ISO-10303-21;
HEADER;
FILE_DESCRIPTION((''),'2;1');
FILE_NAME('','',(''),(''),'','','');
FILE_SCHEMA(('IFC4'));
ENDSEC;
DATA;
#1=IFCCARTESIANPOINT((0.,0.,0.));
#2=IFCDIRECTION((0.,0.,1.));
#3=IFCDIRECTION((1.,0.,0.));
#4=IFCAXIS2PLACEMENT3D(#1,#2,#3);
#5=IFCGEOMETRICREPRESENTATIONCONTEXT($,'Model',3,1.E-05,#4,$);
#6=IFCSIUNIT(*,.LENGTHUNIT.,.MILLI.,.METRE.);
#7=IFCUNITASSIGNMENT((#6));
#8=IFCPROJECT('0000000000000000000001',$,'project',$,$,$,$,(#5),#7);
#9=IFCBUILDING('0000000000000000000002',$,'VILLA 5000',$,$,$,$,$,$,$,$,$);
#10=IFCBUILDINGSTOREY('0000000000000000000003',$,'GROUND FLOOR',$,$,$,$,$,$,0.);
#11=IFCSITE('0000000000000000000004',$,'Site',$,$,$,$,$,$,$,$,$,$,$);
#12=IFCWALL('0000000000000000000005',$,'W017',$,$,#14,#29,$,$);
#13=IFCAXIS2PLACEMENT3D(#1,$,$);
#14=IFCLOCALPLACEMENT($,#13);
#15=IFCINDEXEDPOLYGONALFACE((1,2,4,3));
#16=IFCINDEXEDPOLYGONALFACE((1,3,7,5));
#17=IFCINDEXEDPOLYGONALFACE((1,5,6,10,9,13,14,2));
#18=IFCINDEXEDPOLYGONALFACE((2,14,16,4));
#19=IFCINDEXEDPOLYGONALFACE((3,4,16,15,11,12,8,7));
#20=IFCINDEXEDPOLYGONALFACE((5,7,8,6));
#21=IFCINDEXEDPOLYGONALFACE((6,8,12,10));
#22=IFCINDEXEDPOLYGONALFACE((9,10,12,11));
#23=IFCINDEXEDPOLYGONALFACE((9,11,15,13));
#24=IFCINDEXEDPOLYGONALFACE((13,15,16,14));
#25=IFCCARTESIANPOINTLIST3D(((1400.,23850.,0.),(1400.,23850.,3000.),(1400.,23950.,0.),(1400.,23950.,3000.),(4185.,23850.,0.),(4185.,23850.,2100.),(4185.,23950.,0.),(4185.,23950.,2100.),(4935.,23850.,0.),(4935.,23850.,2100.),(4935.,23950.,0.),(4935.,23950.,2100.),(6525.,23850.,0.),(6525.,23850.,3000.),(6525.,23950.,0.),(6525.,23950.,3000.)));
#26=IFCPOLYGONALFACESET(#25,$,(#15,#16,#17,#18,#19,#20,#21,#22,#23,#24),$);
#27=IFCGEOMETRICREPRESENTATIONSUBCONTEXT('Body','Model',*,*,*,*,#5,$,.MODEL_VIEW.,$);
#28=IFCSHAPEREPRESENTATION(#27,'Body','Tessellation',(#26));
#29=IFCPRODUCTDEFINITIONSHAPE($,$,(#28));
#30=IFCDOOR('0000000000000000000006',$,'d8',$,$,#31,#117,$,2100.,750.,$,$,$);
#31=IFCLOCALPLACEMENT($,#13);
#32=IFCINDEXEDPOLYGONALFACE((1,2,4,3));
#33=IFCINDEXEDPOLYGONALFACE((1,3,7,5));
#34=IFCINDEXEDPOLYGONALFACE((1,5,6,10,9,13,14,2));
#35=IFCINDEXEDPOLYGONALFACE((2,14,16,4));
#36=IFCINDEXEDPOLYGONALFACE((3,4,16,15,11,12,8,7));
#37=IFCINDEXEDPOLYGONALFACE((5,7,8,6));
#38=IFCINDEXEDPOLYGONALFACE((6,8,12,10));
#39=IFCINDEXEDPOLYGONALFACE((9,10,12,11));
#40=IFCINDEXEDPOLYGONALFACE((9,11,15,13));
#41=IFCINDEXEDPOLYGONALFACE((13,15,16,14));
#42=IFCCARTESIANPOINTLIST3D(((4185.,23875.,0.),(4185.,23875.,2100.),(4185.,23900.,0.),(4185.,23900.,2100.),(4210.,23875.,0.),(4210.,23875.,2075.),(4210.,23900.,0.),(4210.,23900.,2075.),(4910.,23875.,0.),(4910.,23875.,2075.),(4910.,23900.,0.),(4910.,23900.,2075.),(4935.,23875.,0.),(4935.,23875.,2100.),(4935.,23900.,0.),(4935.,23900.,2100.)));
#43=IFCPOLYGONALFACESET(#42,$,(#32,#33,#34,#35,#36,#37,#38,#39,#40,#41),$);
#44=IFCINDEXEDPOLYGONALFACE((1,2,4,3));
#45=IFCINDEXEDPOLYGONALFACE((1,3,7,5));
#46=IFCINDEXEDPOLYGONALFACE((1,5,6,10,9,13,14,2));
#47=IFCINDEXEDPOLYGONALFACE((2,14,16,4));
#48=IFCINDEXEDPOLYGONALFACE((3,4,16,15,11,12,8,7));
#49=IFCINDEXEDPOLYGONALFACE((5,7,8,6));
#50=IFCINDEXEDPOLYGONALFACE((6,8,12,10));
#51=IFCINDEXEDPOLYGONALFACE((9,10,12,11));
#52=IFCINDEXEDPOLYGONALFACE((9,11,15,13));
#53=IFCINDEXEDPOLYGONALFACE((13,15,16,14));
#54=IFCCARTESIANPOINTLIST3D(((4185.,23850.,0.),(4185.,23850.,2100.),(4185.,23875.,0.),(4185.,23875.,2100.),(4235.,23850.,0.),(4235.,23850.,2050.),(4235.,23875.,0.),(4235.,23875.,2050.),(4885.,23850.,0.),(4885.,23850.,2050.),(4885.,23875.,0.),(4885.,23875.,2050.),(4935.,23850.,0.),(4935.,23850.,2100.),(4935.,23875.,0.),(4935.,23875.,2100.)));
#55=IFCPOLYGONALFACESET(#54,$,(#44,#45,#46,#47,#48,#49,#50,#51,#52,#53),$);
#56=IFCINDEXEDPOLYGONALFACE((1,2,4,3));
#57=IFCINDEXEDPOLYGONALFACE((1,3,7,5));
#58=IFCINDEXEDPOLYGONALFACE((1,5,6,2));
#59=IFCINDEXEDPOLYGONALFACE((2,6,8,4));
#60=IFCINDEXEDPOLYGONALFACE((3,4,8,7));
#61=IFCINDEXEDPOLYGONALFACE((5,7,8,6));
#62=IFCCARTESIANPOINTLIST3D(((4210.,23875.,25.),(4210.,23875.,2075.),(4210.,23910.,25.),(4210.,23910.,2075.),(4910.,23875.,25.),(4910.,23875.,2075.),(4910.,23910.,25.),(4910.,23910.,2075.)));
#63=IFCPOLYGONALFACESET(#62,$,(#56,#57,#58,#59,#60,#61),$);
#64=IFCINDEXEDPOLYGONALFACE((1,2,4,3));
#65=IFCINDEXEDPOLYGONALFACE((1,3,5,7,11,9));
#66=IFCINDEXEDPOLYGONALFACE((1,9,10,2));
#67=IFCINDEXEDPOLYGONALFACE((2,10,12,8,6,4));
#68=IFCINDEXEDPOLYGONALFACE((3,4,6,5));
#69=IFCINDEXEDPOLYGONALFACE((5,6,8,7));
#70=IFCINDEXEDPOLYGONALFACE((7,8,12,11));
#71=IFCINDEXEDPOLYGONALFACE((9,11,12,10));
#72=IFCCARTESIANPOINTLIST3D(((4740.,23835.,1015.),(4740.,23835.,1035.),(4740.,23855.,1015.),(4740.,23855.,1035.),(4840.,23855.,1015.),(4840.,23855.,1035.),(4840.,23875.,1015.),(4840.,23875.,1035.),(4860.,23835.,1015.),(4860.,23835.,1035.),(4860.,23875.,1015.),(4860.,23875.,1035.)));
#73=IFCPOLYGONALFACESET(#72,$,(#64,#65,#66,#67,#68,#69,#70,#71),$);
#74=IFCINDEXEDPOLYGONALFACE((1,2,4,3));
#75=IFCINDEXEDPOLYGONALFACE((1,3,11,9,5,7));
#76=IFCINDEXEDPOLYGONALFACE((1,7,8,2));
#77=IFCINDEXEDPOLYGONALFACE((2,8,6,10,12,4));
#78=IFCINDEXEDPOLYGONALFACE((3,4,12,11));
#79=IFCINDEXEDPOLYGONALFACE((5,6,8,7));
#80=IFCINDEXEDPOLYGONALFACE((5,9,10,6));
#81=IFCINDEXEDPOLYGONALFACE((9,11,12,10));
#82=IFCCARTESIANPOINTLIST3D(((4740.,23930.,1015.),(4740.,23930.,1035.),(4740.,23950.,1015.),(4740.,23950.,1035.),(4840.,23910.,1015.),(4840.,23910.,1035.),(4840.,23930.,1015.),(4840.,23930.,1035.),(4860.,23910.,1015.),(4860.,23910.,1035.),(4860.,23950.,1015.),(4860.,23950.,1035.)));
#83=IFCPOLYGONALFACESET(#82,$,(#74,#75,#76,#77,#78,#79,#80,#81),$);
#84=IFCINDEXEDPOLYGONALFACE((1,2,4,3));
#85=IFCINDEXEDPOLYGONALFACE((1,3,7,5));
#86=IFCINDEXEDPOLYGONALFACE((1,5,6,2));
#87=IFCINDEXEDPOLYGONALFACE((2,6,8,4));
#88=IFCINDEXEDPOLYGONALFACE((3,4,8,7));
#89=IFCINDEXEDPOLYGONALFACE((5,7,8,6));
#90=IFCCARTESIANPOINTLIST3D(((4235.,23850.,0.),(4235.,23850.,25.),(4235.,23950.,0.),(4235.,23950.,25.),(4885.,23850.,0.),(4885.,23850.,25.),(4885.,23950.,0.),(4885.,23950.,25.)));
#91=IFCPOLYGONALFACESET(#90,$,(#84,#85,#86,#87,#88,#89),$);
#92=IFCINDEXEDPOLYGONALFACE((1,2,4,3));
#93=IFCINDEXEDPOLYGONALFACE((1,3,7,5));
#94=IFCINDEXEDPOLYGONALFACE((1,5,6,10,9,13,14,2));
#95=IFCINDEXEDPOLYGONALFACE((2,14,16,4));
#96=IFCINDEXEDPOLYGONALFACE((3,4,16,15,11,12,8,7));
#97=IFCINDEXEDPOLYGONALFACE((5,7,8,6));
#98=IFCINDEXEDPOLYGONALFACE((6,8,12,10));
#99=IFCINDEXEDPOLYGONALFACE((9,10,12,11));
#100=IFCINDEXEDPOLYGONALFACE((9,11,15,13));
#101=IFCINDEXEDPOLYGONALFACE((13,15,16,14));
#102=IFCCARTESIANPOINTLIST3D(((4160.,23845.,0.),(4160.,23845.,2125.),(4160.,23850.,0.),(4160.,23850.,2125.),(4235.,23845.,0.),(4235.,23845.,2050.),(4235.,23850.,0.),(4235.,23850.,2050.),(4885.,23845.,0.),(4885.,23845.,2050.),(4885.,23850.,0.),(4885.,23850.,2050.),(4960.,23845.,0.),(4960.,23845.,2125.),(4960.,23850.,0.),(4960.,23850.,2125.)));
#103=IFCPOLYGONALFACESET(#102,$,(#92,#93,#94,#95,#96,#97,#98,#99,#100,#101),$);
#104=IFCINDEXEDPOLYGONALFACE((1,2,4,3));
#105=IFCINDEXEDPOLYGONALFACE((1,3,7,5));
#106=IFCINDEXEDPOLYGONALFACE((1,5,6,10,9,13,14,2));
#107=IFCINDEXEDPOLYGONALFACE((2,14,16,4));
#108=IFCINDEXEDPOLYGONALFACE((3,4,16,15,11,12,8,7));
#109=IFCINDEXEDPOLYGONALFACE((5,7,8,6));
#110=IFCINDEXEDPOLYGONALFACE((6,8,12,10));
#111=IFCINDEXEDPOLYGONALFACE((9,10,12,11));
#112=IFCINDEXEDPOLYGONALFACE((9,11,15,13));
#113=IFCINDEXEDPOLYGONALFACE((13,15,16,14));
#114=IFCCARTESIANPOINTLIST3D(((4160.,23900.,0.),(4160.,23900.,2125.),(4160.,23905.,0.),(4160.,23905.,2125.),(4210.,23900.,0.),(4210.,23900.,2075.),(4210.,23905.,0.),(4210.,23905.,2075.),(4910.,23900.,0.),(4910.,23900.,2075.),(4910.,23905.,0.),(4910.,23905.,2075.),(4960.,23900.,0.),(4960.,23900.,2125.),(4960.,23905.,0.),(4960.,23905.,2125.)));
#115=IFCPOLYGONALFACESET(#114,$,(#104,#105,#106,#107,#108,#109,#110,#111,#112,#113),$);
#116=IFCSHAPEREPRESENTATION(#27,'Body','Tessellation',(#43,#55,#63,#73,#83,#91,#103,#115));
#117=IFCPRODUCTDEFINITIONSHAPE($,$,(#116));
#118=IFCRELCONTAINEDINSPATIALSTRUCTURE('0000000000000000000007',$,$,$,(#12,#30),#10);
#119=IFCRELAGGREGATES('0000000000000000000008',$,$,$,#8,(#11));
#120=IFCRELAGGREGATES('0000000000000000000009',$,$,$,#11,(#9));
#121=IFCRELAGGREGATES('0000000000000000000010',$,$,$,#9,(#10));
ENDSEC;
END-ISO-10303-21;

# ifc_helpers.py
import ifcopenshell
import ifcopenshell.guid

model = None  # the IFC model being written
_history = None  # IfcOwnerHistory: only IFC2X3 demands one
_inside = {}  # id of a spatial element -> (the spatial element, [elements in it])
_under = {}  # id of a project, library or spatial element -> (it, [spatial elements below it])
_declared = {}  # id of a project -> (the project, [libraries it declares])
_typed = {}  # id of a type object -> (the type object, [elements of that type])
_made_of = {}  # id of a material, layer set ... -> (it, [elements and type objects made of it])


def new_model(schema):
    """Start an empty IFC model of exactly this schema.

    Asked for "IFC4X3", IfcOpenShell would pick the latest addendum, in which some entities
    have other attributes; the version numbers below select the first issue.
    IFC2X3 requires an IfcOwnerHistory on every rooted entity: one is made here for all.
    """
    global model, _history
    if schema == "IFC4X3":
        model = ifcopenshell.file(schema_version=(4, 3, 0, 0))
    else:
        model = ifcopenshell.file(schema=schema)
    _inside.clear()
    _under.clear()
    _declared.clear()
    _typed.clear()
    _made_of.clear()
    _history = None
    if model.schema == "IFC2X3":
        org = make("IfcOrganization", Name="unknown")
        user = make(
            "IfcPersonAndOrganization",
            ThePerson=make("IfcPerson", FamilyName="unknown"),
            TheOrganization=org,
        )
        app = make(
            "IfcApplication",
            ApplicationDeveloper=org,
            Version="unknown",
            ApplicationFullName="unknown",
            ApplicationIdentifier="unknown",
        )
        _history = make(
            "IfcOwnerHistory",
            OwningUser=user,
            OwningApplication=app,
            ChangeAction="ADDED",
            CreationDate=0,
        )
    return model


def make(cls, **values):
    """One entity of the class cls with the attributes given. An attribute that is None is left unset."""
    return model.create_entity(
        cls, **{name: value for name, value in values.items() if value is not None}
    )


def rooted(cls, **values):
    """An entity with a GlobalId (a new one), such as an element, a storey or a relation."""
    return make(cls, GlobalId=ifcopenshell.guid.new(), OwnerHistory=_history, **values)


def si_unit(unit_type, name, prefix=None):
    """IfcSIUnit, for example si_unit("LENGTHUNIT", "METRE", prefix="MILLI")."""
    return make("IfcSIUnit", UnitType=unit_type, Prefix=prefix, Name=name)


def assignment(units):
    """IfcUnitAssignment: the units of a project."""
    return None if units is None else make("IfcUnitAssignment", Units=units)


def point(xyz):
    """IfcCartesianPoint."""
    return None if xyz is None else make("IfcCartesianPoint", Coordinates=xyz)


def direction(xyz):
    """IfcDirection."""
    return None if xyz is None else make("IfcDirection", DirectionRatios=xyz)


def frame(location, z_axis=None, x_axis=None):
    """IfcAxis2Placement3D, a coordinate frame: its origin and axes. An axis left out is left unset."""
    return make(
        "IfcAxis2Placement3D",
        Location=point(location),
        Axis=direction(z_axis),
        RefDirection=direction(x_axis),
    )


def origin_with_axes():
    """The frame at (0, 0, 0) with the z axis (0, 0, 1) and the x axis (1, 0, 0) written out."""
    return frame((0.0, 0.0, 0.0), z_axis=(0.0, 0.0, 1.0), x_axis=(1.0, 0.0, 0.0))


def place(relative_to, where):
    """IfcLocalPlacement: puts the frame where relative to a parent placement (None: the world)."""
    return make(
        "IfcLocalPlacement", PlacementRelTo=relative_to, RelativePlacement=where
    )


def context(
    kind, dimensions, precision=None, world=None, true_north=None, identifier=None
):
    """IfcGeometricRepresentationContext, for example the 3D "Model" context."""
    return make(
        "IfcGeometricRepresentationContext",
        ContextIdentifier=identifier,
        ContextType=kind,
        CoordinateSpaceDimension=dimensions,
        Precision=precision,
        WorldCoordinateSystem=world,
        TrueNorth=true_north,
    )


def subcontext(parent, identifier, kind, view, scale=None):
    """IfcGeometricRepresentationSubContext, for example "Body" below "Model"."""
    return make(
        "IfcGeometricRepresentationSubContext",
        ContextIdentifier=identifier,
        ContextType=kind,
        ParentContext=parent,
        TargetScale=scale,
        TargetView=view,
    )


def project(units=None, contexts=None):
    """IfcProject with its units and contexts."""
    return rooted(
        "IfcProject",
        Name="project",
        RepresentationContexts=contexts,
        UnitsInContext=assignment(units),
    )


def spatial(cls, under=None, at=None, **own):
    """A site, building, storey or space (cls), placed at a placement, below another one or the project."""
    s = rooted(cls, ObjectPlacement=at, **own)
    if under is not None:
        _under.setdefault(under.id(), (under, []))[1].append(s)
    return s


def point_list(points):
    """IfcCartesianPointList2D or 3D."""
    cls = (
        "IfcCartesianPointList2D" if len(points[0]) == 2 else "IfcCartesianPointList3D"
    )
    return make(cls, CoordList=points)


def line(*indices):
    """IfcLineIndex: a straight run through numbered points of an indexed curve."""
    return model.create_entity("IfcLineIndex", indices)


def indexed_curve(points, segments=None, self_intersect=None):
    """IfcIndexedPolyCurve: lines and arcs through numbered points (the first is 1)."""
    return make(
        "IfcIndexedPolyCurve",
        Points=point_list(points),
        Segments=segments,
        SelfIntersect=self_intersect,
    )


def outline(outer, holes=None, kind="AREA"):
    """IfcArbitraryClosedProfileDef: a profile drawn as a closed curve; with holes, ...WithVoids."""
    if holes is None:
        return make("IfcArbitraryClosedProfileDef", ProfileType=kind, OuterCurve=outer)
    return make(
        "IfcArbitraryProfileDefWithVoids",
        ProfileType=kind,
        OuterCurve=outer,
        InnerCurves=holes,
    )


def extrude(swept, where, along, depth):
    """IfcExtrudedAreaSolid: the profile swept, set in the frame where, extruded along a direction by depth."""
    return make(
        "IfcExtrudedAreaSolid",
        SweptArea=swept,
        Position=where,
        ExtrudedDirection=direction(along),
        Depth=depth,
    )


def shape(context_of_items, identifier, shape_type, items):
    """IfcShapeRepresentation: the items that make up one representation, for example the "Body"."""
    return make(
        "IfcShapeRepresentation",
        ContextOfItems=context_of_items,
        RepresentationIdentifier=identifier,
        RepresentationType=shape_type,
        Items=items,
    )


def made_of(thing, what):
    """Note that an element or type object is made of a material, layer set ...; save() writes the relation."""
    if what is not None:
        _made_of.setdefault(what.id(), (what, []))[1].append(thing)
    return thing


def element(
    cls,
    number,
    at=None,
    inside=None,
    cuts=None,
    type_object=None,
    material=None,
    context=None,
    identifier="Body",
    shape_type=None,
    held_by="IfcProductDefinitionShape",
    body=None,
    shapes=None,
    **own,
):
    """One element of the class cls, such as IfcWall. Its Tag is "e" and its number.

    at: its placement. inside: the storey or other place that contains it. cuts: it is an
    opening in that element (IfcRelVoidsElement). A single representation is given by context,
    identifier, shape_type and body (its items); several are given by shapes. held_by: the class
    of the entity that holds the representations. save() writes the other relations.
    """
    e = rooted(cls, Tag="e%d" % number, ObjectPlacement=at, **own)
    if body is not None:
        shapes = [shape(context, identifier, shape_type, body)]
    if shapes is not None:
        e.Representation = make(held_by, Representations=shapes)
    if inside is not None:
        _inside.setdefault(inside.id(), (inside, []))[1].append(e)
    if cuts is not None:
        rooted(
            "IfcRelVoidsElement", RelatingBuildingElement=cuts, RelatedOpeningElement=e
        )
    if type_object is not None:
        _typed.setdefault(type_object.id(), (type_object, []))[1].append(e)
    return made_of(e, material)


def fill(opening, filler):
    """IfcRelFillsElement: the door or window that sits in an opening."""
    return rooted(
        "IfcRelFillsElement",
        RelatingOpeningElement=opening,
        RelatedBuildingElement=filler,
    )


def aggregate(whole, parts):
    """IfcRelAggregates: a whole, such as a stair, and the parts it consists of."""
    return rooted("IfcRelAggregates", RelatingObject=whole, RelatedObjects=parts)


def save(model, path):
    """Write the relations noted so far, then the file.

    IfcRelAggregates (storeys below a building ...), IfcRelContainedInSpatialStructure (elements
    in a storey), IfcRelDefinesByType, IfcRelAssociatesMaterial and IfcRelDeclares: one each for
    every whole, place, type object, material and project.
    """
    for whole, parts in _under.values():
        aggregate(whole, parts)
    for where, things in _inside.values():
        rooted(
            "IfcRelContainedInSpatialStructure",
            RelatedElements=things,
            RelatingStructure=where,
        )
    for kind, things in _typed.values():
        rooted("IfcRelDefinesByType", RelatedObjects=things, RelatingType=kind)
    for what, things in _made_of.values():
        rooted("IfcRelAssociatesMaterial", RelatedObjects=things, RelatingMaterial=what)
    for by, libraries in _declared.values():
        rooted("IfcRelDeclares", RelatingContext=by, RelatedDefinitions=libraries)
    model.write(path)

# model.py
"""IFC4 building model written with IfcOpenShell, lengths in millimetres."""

from ifc_helpers import new_model, si_unit, frame, origin_with_axes, place, context, subcontext, project, spatial, line, indexed_curve, outline, extrude, element, fill, save


model = new_model("IFC4")

# Units and contexts
model_context = context("Model", 3, precision=1e-05, world=origin_with_axes())
body_context = subcontext(model_context, "Body", "Model", "MODEL_VIEW")
ifc_project = project(units=[si_unit("LENGTHUNIT", "METRE", prefix="MILLI")], contexts=[model_context])

# Site, building, storey
site = spatial("IfcSite", under=ifc_project, Name="Site")
building = spatial("IfcBuilding", under=site, Name="VILLA 5000")
storey = spatial("IfcBuildingStorey", under=building, Name="GROUND FLOOR", Elevation=0.0)

# Wall, opening, door
wall_1_placement = place(None, frame((1400.0, 23900.0, 0.0), z_axis=(0.0, 0.0, 1.0), x_axis=(1.0, 0.0, 0.0)))
wall_1 = element("IfcWall", 1, at=wall_1_placement, inside=storey, Name="W017", context=body_context, shape_type="SweptSolid", body=[
    extrude(outline(indexed_curve([(0.0, 0.0), (0.0, 100.0), (5125.0, 100.0), (5125.0, 0.0), (0.0, 0.0)], self_intersect=False)), frame((0.0, -50.0, 0.0), z_axis=(0.0, 0.0, 1.0), x_axis=(1.0, 0.0, 0.0)), (0.0, 0.0, 1.0), 3000.0),
])
opening_1_placement = place(wall_1_placement, frame((2785.0, 0.0, 0.0), z_axis=(0.0, 0.0, 1.0), x_axis=(1.0, 0.0, 0.0)))
opening_1 = element("IfcOpeningElement", 2, at=opening_1_placement, cuts=wall_1, context=body_context, shape_type="SweptSolid", body=[
    extrude(outline(indexed_curve([(0.0, 0.0), (0.0, 200.0), (750.0, 200.0), (750.0, 0.0), (0.0, 0.0)], self_intersect=False)), frame((0.0, -100.0, 0.0), z_axis=(0.0, 0.0, 1.0), x_axis=(1.0, 0.0, 0.0)), (0.0, 0.0, 1.0), 2100.0),
])
door_1_placement = place(None, frame((4185.0, 23850.0, 0.0), z_axis=(0.0, 0.0, 1.0), x_axis=(1.0, 0.0, 0.0)))
door_1 = element("IfcDoor", 3, at=door_1_placement, inside=storey, Name="d8", OverallHeight=2100.0, OverallWidth=750.0, context=body_context, shape_type="SweptSolid", body=[
    extrude(outline(indexed_curve([(0.0, 0.0), (0.0, 2100.0), (750.0, 2100.0), (750.0, 0.0), (725.0, 0.0), (725.0, 2075.0), (25.0, 2075.0), (25.0, 0.0)], segments=[line(1, 2, 3, 4, 5, 6, 7, 8, 1)])), frame((0.0, 25.0, 0.0), z_axis=(0.0, -1.0, 0.0), x_axis=(1.0, 0.0, 0.0)), (0.0, 0.0, -1.0), 25.0),
    extrude(outline(indexed_curve([(0.0, 0.0), (0.0, 2100.0), (750.0, 2100.0), (750.0, 0.0), (700.0, 0.0), (700.0, 2050.0), (50.0, 2050.0), (50.0, 0.0)], segments=[line(1, 2, 3, 4, 5, 6, 7, 8, 1)])), frame((0.0, 0.0, 0.0), z_axis=(0.0, -1.0, 0.0), x_axis=(1.0, 0.0, 0.0)), (0.0, 0.0, -1.0), 25.0),
    extrude(outline(indexed_curve([(0.0, 0.0), (700.0, 0.0), (700.0, 35.0), (0.0, 35.0)], segments=[line(1, 2, 3, 4, 1)])), frame((25.0, 25.0, 25.0), z_axis=(0.0, 0.0, 1.0), x_axis=(1.0, 0.0, 0.0)), (0.0, 0.0, 1.0), 2050.0),
    extrude(outline(indexed_curve([(0.0, 0.0), (0.0, -40.0), (-120.0, -40.0), (-120.0, -20.0), (-20.0, -20.0), (-20.0, 0.0)], segments=[line(1, 2, 3, 4, 5, 6, 1)])), frame((675.0, 25.0, 1015.0), z_axis=(0.0, 0.0, 1.0), x_axis=(1.0, 0.0, 0.0)), (0.0, 0.0, 1.0), 20.0),
    extrude(outline(indexed_curve([(0.0, 0.0), (0.0, 40.0), (-120.0, 40.0), (-120.0, 20.0), (-20.0, 20.0), (-20.0, 0.0)], segments=[line(1, 2, 3, 4, 5, 6, 1)])), frame((675.0, 60.0, 1015.0), z_axis=(0.0, 0.0, 1.0), x_axis=(1.0, 0.0, 0.0)), (0.0, 0.0, 1.0), 20.0),
    extrude(outline(indexed_curve([(0.0, 0.0), (650.0, 0.0), (650.0, 100.0), (0.0, 100.0)], segments=[line(1, 2, 3, 4, 1)])), frame((50.0, 0.0, 0.0), z_axis=(0.0, 0.0, 1.0), x_axis=(1.0, 0.0, 0.0)), (0.0, 0.0, 1.0), 25.0),
    extrude(outline(indexed_curve([(0.0, 0.0), (0.0, 2125.0), (800.0, 2125.0), (800.0, 0.0), (725.0, 0.0), (725.0, 2050.0), (75.0, 2050.0), (75.0, 0.0)], segments=[line(1, 2, 3, 4, 5, 6, 7, 8, 1)])), frame((-25.0, -5.0, 0.0), z_axis=(0.0, -1.0, 0.0), x_axis=(1.0, 0.0, 0.0)), (0.0, 0.0, -1.0), 5.0),
    extrude(outline(indexed_curve([(0.0, 0.0), (0.0, 2125.0), (800.0, 2125.0), (800.0, 0.0), (750.0, 0.0), (750.0, 2075.0), (50.0, 2075.0), (50.0, 0.0)], segments=[line(1, 2, 3, 4, 5, 6, 7, 8, 1)])), frame((-25.0, 50.0, 0.0), z_axis=(0.0, -1.0, 0.0), x_axis=(1.0, 0.0, 0.0)), (0.0, 0.0, -1.0), 5.0),
])
fill(opening_1, door_1)

save(model, "model.ifc")
